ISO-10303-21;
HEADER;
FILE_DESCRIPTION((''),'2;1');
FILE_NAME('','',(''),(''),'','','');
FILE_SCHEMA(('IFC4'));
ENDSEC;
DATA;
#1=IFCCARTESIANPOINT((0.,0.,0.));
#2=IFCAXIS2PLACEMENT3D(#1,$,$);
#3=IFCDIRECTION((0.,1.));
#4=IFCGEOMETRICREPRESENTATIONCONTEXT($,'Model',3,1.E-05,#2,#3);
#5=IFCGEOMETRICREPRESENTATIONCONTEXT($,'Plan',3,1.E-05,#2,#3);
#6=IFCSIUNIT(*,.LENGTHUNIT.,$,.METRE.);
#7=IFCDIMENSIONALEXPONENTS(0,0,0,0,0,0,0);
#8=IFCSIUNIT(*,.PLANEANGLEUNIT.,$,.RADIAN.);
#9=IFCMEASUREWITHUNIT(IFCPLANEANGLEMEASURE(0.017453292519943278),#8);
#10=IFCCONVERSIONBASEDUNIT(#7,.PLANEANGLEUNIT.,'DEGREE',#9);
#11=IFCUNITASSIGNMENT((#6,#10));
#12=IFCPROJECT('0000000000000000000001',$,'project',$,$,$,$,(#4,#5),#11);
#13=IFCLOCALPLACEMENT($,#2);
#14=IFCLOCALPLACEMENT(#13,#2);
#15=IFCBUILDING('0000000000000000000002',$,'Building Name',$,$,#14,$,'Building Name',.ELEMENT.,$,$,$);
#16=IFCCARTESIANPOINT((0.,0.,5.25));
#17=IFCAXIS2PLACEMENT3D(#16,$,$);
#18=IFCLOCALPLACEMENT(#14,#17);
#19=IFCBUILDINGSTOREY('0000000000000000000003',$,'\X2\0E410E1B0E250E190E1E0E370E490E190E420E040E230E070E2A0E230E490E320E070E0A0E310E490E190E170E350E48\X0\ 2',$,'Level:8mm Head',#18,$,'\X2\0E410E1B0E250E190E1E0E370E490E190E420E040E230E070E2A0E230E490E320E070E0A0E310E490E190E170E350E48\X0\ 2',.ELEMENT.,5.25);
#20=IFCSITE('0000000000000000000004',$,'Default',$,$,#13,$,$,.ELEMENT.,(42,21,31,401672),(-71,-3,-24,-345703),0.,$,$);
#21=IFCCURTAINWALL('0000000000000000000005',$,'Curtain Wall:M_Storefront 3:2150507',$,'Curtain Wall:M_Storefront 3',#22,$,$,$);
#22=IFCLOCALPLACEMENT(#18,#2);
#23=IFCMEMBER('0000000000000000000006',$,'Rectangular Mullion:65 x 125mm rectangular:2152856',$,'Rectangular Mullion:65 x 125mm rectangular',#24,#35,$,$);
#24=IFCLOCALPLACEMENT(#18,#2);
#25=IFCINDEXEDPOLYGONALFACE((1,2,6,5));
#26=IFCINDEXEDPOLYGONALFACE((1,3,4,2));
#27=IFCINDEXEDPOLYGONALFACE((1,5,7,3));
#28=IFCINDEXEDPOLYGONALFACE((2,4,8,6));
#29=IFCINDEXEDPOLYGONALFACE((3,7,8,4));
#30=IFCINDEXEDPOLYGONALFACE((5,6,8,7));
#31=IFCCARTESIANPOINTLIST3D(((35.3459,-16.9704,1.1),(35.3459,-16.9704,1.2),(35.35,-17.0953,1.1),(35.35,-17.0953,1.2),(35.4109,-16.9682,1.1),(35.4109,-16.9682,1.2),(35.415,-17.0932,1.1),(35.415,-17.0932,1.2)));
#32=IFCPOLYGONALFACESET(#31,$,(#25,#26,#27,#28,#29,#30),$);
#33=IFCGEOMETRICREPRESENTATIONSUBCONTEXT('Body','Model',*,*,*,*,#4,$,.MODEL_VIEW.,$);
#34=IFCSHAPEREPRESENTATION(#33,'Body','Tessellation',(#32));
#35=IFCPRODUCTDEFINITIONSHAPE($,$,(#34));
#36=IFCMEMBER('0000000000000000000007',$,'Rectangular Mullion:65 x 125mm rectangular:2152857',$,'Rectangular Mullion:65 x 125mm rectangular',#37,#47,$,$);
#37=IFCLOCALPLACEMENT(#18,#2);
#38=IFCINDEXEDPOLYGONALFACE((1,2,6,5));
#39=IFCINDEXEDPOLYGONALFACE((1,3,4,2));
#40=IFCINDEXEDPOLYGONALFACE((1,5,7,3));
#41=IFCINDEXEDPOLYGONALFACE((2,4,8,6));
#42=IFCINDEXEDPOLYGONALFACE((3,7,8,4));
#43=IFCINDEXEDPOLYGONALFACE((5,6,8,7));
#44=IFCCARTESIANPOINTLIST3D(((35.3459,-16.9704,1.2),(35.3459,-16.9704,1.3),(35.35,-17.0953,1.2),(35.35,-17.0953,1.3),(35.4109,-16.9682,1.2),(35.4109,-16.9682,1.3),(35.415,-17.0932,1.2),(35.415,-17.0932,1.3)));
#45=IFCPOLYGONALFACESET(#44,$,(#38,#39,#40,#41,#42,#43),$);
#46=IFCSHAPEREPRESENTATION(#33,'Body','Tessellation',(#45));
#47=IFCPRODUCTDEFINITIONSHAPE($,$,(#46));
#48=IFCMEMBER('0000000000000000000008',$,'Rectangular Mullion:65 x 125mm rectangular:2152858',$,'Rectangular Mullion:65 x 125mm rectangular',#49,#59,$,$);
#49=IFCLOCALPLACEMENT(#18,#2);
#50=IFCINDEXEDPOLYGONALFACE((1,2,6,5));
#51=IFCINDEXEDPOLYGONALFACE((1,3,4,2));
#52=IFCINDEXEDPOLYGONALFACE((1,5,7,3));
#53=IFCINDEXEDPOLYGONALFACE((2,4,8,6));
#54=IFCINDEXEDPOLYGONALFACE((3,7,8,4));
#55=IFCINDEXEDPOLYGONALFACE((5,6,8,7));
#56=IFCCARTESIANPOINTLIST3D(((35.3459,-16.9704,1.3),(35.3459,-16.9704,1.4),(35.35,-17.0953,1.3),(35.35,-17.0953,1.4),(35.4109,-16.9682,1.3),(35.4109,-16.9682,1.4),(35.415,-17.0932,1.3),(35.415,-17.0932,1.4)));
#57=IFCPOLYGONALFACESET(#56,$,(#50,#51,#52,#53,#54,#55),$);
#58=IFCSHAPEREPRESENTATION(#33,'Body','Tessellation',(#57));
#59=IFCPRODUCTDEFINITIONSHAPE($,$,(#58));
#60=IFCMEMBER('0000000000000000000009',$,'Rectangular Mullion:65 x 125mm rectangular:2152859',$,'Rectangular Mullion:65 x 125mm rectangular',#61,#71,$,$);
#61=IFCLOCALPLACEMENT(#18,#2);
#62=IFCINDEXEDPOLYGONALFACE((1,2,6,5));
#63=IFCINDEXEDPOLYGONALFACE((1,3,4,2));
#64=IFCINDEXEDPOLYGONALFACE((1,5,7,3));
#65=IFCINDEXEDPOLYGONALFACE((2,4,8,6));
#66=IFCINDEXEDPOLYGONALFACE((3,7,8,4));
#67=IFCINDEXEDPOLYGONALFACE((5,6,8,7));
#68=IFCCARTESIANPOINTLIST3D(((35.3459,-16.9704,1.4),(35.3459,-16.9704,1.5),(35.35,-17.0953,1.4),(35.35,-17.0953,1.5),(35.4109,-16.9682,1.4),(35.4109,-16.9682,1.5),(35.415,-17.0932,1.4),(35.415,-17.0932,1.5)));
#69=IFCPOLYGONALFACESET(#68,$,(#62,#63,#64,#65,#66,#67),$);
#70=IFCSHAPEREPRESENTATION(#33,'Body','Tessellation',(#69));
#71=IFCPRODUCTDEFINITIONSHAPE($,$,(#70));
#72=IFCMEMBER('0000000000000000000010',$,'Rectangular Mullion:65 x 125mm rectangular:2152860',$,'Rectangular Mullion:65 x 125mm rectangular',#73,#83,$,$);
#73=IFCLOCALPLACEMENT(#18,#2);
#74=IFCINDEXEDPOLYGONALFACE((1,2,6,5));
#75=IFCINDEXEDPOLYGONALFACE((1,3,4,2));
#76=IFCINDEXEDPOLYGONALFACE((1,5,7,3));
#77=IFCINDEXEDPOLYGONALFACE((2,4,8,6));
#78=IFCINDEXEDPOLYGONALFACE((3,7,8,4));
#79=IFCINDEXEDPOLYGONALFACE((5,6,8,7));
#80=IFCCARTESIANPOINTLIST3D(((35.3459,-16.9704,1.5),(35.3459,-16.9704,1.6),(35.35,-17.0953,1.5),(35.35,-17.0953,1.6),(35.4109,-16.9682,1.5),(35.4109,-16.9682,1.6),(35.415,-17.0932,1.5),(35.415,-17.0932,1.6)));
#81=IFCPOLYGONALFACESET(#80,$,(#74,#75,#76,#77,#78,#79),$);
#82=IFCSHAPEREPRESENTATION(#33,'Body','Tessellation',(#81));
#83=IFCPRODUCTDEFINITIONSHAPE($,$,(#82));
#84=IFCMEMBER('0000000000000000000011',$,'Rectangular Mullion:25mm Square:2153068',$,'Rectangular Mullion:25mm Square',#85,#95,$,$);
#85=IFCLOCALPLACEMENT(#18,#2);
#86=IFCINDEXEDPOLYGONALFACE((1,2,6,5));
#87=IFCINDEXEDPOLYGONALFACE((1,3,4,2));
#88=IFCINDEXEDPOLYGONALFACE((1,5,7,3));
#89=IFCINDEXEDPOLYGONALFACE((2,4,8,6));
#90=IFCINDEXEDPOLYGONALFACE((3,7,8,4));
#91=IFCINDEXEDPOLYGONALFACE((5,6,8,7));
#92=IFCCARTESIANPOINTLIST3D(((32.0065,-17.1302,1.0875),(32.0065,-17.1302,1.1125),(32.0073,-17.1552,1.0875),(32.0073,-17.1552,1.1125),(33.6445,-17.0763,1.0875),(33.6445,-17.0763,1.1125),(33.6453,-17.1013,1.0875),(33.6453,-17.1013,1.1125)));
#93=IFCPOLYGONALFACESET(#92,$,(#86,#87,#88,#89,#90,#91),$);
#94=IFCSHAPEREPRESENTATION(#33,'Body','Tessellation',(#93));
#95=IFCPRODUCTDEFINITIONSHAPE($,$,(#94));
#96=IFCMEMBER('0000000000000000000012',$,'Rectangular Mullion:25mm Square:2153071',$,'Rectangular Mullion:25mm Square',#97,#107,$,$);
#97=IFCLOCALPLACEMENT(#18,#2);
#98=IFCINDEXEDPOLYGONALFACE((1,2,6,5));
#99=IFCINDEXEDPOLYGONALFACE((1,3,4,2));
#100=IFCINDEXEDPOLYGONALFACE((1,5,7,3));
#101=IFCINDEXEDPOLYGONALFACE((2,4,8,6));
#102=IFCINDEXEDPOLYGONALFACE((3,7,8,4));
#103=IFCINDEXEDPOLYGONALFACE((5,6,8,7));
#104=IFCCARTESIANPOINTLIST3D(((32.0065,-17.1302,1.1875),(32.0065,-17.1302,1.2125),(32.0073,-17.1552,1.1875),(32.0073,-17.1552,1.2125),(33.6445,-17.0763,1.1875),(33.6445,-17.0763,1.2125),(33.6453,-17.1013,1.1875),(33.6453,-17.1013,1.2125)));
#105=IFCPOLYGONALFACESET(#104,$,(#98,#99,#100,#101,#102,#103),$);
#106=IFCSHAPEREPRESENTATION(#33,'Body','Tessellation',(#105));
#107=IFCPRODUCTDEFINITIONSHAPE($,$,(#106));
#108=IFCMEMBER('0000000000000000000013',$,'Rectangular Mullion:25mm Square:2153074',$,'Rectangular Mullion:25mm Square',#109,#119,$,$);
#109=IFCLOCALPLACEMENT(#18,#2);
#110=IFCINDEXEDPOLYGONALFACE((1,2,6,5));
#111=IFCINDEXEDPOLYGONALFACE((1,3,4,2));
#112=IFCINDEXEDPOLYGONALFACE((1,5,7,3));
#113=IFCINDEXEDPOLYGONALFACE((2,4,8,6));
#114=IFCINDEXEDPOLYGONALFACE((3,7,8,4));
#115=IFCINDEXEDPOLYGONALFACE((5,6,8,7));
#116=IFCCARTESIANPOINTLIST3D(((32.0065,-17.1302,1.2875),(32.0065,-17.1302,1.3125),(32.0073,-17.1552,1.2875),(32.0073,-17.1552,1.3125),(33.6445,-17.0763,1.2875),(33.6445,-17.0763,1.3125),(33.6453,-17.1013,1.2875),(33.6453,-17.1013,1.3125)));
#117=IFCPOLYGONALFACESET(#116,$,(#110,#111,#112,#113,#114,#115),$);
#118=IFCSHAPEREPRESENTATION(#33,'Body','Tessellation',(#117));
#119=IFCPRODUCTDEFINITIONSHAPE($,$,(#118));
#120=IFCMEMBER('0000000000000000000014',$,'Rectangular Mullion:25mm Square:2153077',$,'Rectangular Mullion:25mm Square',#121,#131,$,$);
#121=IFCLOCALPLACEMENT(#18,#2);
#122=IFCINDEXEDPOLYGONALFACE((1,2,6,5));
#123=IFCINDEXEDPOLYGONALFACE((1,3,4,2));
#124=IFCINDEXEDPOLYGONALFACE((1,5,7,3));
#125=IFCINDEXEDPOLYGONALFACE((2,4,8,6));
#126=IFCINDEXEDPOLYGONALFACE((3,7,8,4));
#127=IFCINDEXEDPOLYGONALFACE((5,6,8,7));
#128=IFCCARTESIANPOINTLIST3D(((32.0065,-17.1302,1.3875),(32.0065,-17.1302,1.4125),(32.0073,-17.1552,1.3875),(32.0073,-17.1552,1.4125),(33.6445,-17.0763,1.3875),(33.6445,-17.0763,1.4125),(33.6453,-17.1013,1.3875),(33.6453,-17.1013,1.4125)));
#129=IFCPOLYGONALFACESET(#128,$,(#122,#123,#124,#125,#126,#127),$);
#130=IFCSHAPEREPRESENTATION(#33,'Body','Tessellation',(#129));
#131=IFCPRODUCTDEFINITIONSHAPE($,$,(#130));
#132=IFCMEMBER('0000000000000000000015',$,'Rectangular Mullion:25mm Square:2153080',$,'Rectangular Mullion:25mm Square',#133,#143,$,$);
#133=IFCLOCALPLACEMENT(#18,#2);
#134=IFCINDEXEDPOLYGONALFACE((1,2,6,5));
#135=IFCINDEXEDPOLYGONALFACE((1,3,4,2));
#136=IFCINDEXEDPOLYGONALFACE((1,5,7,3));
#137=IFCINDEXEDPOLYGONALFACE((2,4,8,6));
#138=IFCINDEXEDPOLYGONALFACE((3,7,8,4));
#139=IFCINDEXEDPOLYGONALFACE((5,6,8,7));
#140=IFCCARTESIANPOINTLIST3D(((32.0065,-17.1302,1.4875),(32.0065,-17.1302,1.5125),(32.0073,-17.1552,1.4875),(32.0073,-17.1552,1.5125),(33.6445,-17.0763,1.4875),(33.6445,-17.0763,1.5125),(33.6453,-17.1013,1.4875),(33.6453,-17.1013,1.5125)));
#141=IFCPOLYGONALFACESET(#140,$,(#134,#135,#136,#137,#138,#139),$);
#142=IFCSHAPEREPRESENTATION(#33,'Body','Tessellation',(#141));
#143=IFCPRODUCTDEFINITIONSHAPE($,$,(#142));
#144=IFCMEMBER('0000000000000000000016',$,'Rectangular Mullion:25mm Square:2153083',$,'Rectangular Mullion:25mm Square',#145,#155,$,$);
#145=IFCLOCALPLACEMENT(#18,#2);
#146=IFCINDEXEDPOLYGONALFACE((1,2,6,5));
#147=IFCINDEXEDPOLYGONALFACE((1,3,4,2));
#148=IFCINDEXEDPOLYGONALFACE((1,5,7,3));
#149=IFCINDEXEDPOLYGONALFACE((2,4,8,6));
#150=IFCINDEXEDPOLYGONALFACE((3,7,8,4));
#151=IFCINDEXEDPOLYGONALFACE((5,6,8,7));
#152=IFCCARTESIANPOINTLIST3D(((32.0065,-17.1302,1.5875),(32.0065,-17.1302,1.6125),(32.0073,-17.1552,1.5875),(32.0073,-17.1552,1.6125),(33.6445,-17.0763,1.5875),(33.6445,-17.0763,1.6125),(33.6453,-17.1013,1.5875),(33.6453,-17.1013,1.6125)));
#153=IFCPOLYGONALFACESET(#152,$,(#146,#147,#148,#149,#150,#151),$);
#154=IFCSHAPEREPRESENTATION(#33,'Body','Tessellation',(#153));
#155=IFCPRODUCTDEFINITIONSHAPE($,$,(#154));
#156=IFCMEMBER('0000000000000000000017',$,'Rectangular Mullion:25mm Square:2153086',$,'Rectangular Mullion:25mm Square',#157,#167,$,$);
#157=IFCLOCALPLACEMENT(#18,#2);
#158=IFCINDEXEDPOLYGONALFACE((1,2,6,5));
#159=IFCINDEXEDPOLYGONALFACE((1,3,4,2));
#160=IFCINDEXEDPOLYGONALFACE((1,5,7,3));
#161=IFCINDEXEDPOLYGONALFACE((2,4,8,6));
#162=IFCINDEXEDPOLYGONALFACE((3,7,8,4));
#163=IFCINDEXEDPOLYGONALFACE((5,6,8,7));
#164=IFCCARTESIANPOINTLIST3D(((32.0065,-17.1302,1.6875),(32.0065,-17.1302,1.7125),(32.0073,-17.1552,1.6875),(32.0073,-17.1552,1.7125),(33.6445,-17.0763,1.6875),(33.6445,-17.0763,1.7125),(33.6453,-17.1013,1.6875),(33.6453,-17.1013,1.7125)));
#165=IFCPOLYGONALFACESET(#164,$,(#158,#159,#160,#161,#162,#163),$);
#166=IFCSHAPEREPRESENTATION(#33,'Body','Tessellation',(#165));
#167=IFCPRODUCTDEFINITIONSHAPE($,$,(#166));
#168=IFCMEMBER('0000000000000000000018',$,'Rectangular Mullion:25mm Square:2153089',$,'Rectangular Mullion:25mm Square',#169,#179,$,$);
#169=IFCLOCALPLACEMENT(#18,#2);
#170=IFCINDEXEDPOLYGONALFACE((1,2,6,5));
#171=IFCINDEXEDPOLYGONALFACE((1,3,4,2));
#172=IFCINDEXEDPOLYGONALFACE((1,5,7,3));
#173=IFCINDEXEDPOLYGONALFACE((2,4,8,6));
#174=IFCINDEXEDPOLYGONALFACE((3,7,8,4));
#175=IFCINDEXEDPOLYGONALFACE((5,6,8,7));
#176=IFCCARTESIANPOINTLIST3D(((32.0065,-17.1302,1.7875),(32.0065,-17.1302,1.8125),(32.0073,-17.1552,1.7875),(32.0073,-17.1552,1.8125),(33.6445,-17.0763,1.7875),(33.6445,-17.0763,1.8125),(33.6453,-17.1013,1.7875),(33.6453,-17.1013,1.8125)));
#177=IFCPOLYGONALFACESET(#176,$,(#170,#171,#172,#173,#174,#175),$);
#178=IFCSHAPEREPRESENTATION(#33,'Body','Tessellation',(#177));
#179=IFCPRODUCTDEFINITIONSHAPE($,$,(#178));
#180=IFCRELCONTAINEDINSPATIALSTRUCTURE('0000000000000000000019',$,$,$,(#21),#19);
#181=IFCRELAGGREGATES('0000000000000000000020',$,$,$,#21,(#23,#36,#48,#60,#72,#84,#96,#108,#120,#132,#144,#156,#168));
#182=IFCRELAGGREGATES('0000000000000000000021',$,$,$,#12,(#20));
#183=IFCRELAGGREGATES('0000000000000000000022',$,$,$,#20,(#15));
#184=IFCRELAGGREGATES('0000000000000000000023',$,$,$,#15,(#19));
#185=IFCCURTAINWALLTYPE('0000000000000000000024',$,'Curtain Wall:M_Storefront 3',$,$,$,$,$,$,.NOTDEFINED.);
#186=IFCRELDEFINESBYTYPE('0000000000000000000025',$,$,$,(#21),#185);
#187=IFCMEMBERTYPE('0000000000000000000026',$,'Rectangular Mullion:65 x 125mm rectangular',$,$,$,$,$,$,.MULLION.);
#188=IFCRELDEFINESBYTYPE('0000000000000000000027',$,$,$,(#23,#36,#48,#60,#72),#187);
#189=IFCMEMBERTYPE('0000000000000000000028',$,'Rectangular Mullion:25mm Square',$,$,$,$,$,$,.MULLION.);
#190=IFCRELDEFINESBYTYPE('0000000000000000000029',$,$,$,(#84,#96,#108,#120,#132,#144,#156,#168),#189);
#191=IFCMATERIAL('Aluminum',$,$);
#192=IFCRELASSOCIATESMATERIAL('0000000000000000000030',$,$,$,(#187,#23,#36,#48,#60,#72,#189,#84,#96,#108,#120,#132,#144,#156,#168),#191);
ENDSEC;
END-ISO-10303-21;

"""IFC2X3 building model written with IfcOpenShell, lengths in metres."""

from ifc_helpers import new_model, entity, si_unit, converted_unit, direction, frame, origin, origin_2d_with_axis, place, context, subcontext, project, spatial, rectangle, extrude, source, transform, mapped, material, type_object, type_shapes, element, aggregate, save


model = new_model("IFC2X3")

# Units and contexts
model_context = context("Model", 3, precision=1e-05, world=origin(), true_north=direction((0.0, 1.0)))
plan_context = context("Plan", 3, precision=1e-05, world=origin(), true_north=direction((0.0, 1.0)))
body_context = subcontext(model_context, "Body", "Model", "MODEL_VIEW")
ifc_project = project(units=[si_unit("LENGTHUNIT", "METRE"), converted_unit("PLANEANGLEUNIT", "DEGREE", entity("IfcPlaneAngleMeasure", 0.017453292519943278), si_unit("PLANEANGLEUNIT", "RADIAN"), dimensions=[0, 0, 0, 0, 0, 0, 0])], contexts=[model_context, plan_context])

# Site, building, storey
site_placement = place(None, origin())
site = spatial("IfcSite", under=ifc_project, at=site_placement, Name="Default", CompositionType="ELEMENT", RefLatitude=(42, 21, 31, 401672), RefLongitude=(-71, -3, -24, -345703), RefElevation=0.0)
building_placement = place(site_placement, origin())
building = spatial("IfcBuilding", under=site, at=building_placement, Name="Building Name", LongName="Building Name", CompositionType="ELEMENT")
storey_placement = place(building_placement, frame((0.0, 0.0, 5.25)))
storey = spatial("IfcBuildingStorey", under=building, at=storey_placement, Name="แปลนพื้นโครงสร้างชั้นที่ 2", ObjectType="Level:8mm Head", LongName="แปลนพื้นโครงสร้างชั้นที่ 2", CompositionType="ELEMENT", Elevation=5.25)

# Curtain wall, members
curtain_wall_type = type_object("IfcCurtainWallType", Name="Curtain Wall:M_Storefront 3", PredefinedType="NOTDEFINED")
curtain_wall_placement = place(storey_placement, frame((0.0, 0.0, -5.25)))
curtain_wall = element("IfcCurtainWall", 1, at=curtain_wall_placement, inside=storey, type_object=curtain_wall_type, Name="Curtain Wall:M_Storefront 3:2150507", ObjectType="Curtain Wall:M_Storefront 3")
ifc_material = material(Name="Aluminum")
member_type_1 = type_object("IfcMemberType", Name="Rectangular Mullion:65 x 125mm rectangular", PredefinedType="MULLION", material=ifc_material)
shared_shape_1 = source(origin(), body_context, "Body", "SweptSolid", [
    extrude(rectangle(XDim=0.065, YDim=0.125, at=origin_2d_with_axis()), frame((-0.0325, 0.0, -0.1), z_axis=(0.0, 0.0, 1.0), x_axis=(-1.0, 0.0, 0.0)), (0.0, 0.0, 1.0), 0.1),
])
type_shapes(member_type_1, [shared_shape_1])
member_1_placement = place(curtain_wall_placement, frame((35.4129, -17.0307, 6.35), z_axis=(0.0, 0.0, -1.0), x_axis=(0.99946, 0.032862, 0.0)))
member_1 = element("IfcMember", 2, at=member_1_placement, type_object=member_type_1, material=ifc_material, Name="Rectangular Mullion:65 x 125mm rectangular:2152856", ObjectType="Rectangular Mullion:65 x 125mm rectangular", context=body_context, shape_type="MappedRepresentation", body=[
    mapped(shared_shape_1, transform((0.0, 0.0, 0.0), scale=1.0)),
])
member_2_placement = place(curtain_wall_placement, frame((35.4129, -17.0307, 6.45), z_axis=(0.0, 0.0, -1.0), x_axis=(0.99946, 0.032862, 0.0)))
member_2 = element("IfcMember", 3, at=member_2_placement, type_object=member_type_1, material=ifc_material, Name="Rectangular Mullion:65 x 125mm rectangular:2152857", ObjectType="Rectangular Mullion:65 x 125mm rectangular", context=body_context, shape_type="MappedRepresentation", body=[
    mapped(shared_shape_1, transform((0.0, 0.0, 0.0), scale=1.0)),
])
member_3_placement = place(curtain_wall_placement, frame((35.4129, -17.0307, 6.55), z_axis=(0.0, 0.0, -1.0), x_axis=(0.99946, 0.032862, 0.0)))
member_3 = element("IfcMember", 4, at=member_3_placement, type_object=member_type_1, material=ifc_material, Name="Rectangular Mullion:65 x 125mm rectangular:2152858", ObjectType="Rectangular Mullion:65 x 125mm rectangular", context=body_context, shape_type="MappedRepresentation", body=[
    mapped(shared_shape_1, transform((0.0, 0.0, 0.0), scale=1.0)),
])
member_4_placement = place(curtain_wall_placement, frame((35.4129, -17.0307, 6.65), z_axis=(0.0, 0.0, -1.0), x_axis=(0.99946, 0.032862, 0.0)))
member_4 = element("IfcMember", 5, at=member_4_placement, type_object=member_type_1, material=ifc_material, Name="Rectangular Mullion:65 x 125mm rectangular:2152859", ObjectType="Rectangular Mullion:65 x 125mm rectangular", context=body_context, shape_type="MappedRepresentation", body=[
    mapped(shared_shape_1, transform((0.0, 0.0, 0.0), scale=1.0)),
])
member_5_placement = place(curtain_wall_placement, frame((35.4129, -17.0307, 6.75), z_axis=(0.0, 0.0, -1.0), x_axis=(0.99946, 0.032862, 0.0)))
member_5 = element("IfcMember", 6, at=member_5_placement, type_object=member_type_1, material=ifc_material, Name="Rectangular Mullion:65 x 125mm rectangular:2152860", ObjectType="Rectangular Mullion:65 x 125mm rectangular", context=body_context, shape_type="MappedRepresentation", body=[
    mapped(shared_shape_1, transform((0.0, 0.0, 0.0), scale=1.0)),
])
member_type_2 = type_object("IfcMemberType", Name="Rectangular Mullion:25mm Square", PredefinedType="MULLION", material=ifc_material)
shared_shape_2 = source(origin(), body_context, "Body", "SweptSolid", [
    extrude(rectangle(XDim=0.025, YDim=0.025, at=origin_2d_with_axis()), frame((0.0, 0.0, -1.6389), z_axis=(0.0, 0.0, 1.0), x_axis=(-1.0, 0.0, 0.0)), (0.0, 0.0, 1.0), 1.6389),
])
type_shapes(member_type_2, [shared_shape_2])
member_6_placement = place(curtain_wall_placement, frame((33.6449, -17.0888, 6.35), z_axis=(0.99946, 0.032862, 0.0), x_axis=(0.0, 0.0, 1.0)))
member_6 = element("IfcMember", 7, at=member_6_placement, type_object=member_type_2, material=ifc_material, Name="Rectangular Mullion:25mm Square:2153068", ObjectType="Rectangular Mullion:25mm Square", context=body_context, shape_type="MappedRepresentation", body=[
    mapped(shared_shape_2, transform((0.0, 0.0, 0.0), scale=1.0)),
])
member_7_placement = place(curtain_wall_placement, frame((33.6449, -17.0888, 6.45), z_axis=(0.99946, 0.032862, 0.0), x_axis=(0.0, 0.0, 1.0)))
member_7 = element("IfcMember", 8, at=member_7_placement, type_object=member_type_2, material=ifc_material, Name="Rectangular Mullion:25mm Square:2153071", ObjectType="Rectangular Mullion:25mm Square", context=body_context, shape_type="MappedRepresentation", body=[
    mapped(shared_shape_2, transform((0.0, 0.0, 0.0), scale=1.0)),
])
member_8_placement = place(curtain_wall_placement, frame((33.6449, -17.0888, 6.55), z_axis=(0.99946, 0.032862, 0.0), x_axis=(0.0, 0.0, 1.0)))
member_8 = element("IfcMember", 9, at=member_8_placement, type_object=member_type_2, material=ifc_material, Name="Rectangular Mullion:25mm Square:2153074", ObjectType="Rectangular Mullion:25mm Square", context=body_context, shape_type="MappedRepresentation", body=[
    mapped(shared_shape_2, transform((0.0, 0.0, 0.0), scale=1.0)),
])
member_9_placement = place(curtain_wall_placement, frame((33.6449, -17.0888, 6.65), z_axis=(0.99946, 0.032862, 0.0), x_axis=(0.0, 0.0, 1.0)))
member_9 = element("IfcMember", 10, at=member_9_placement, type_object=member_type_2, material=ifc_material, Name="Rectangular Mullion:25mm Square:2153077", ObjectType="Rectangular Mullion:25mm Square", context=body_context, shape_type="MappedRepresentation", body=[
    mapped(shared_shape_2, transform((0.0, 0.0, 0.0), scale=1.0)),
])
member_10_placement = place(curtain_wall_placement, frame((33.6449, -17.0888, 6.75), z_axis=(0.99946, 0.032862, 0.0), x_axis=(0.0, 0.0, 1.0)))
member_10 = element("IfcMember", 11, at=member_10_placement, type_object=member_type_2, material=ifc_material, Name="Rectangular Mullion:25mm Square:2153080", ObjectType="Rectangular Mullion:25mm Square", context=body_context, shape_type="MappedRepresentation", body=[
    mapped(shared_shape_2, transform((0.0, 0.0, 0.0), scale=1.0)),
])
member_11_placement = place(curtain_wall_placement, frame((33.6449, -17.0888, 6.85), z_axis=(0.99946, 0.032862, 0.0), x_axis=(0.0, 0.0, 1.0)))
member_11 = element("IfcMember", 12, at=member_11_placement, type_object=member_type_2, material=ifc_material, Name="Rectangular Mullion:25mm Square:2153083", ObjectType="Rectangular Mullion:25mm Square", context=body_context, shape_type="MappedRepresentation", body=[
    mapped(shared_shape_2, transform((0.0, 0.0, 0.0), scale=1.0)),
])
member_12_placement = place(curtain_wall_placement, frame((33.6449, -17.0888, 6.95), z_axis=(0.99946, 0.032862, 0.0), x_axis=(0.0, 0.0, 1.0)))
member_12 = element("IfcMember", 13, at=member_12_placement, type_object=member_type_2, material=ifc_material, Name="Rectangular Mullion:25mm Square:2153086", ObjectType="Rectangular Mullion:25mm Square", context=body_context, shape_type="MappedRepresentation", body=[
    mapped(shared_shape_2, transform((0.0, 0.0, 0.0), scale=1.0)),
])
member_13_placement = place(curtain_wall_placement, frame((33.6449, -17.0888, 7.05), z_axis=(0.99946, 0.032862, 0.0), x_axis=(0.0, 0.0, 1.0)))
member_13 = element("IfcMember", 14, at=member_13_placement, type_object=member_type_2, material=ifc_material, Name="Rectangular Mullion:25mm Square:2153089", ObjectType="Rectangular Mullion:25mm Square", context=body_context, shape_type="MappedRepresentation", body=[
    mapped(shared_shape_2, transform((0.0, 0.0, 0.0), scale=1.0)),
])
aggregate(curtain_wall, [member_1, member_2, member_3, member_4, member_5, member_6, member_7, member_8, member_9, member_10, member_11, member_12, member_13])

save(model, "model.ifc")
